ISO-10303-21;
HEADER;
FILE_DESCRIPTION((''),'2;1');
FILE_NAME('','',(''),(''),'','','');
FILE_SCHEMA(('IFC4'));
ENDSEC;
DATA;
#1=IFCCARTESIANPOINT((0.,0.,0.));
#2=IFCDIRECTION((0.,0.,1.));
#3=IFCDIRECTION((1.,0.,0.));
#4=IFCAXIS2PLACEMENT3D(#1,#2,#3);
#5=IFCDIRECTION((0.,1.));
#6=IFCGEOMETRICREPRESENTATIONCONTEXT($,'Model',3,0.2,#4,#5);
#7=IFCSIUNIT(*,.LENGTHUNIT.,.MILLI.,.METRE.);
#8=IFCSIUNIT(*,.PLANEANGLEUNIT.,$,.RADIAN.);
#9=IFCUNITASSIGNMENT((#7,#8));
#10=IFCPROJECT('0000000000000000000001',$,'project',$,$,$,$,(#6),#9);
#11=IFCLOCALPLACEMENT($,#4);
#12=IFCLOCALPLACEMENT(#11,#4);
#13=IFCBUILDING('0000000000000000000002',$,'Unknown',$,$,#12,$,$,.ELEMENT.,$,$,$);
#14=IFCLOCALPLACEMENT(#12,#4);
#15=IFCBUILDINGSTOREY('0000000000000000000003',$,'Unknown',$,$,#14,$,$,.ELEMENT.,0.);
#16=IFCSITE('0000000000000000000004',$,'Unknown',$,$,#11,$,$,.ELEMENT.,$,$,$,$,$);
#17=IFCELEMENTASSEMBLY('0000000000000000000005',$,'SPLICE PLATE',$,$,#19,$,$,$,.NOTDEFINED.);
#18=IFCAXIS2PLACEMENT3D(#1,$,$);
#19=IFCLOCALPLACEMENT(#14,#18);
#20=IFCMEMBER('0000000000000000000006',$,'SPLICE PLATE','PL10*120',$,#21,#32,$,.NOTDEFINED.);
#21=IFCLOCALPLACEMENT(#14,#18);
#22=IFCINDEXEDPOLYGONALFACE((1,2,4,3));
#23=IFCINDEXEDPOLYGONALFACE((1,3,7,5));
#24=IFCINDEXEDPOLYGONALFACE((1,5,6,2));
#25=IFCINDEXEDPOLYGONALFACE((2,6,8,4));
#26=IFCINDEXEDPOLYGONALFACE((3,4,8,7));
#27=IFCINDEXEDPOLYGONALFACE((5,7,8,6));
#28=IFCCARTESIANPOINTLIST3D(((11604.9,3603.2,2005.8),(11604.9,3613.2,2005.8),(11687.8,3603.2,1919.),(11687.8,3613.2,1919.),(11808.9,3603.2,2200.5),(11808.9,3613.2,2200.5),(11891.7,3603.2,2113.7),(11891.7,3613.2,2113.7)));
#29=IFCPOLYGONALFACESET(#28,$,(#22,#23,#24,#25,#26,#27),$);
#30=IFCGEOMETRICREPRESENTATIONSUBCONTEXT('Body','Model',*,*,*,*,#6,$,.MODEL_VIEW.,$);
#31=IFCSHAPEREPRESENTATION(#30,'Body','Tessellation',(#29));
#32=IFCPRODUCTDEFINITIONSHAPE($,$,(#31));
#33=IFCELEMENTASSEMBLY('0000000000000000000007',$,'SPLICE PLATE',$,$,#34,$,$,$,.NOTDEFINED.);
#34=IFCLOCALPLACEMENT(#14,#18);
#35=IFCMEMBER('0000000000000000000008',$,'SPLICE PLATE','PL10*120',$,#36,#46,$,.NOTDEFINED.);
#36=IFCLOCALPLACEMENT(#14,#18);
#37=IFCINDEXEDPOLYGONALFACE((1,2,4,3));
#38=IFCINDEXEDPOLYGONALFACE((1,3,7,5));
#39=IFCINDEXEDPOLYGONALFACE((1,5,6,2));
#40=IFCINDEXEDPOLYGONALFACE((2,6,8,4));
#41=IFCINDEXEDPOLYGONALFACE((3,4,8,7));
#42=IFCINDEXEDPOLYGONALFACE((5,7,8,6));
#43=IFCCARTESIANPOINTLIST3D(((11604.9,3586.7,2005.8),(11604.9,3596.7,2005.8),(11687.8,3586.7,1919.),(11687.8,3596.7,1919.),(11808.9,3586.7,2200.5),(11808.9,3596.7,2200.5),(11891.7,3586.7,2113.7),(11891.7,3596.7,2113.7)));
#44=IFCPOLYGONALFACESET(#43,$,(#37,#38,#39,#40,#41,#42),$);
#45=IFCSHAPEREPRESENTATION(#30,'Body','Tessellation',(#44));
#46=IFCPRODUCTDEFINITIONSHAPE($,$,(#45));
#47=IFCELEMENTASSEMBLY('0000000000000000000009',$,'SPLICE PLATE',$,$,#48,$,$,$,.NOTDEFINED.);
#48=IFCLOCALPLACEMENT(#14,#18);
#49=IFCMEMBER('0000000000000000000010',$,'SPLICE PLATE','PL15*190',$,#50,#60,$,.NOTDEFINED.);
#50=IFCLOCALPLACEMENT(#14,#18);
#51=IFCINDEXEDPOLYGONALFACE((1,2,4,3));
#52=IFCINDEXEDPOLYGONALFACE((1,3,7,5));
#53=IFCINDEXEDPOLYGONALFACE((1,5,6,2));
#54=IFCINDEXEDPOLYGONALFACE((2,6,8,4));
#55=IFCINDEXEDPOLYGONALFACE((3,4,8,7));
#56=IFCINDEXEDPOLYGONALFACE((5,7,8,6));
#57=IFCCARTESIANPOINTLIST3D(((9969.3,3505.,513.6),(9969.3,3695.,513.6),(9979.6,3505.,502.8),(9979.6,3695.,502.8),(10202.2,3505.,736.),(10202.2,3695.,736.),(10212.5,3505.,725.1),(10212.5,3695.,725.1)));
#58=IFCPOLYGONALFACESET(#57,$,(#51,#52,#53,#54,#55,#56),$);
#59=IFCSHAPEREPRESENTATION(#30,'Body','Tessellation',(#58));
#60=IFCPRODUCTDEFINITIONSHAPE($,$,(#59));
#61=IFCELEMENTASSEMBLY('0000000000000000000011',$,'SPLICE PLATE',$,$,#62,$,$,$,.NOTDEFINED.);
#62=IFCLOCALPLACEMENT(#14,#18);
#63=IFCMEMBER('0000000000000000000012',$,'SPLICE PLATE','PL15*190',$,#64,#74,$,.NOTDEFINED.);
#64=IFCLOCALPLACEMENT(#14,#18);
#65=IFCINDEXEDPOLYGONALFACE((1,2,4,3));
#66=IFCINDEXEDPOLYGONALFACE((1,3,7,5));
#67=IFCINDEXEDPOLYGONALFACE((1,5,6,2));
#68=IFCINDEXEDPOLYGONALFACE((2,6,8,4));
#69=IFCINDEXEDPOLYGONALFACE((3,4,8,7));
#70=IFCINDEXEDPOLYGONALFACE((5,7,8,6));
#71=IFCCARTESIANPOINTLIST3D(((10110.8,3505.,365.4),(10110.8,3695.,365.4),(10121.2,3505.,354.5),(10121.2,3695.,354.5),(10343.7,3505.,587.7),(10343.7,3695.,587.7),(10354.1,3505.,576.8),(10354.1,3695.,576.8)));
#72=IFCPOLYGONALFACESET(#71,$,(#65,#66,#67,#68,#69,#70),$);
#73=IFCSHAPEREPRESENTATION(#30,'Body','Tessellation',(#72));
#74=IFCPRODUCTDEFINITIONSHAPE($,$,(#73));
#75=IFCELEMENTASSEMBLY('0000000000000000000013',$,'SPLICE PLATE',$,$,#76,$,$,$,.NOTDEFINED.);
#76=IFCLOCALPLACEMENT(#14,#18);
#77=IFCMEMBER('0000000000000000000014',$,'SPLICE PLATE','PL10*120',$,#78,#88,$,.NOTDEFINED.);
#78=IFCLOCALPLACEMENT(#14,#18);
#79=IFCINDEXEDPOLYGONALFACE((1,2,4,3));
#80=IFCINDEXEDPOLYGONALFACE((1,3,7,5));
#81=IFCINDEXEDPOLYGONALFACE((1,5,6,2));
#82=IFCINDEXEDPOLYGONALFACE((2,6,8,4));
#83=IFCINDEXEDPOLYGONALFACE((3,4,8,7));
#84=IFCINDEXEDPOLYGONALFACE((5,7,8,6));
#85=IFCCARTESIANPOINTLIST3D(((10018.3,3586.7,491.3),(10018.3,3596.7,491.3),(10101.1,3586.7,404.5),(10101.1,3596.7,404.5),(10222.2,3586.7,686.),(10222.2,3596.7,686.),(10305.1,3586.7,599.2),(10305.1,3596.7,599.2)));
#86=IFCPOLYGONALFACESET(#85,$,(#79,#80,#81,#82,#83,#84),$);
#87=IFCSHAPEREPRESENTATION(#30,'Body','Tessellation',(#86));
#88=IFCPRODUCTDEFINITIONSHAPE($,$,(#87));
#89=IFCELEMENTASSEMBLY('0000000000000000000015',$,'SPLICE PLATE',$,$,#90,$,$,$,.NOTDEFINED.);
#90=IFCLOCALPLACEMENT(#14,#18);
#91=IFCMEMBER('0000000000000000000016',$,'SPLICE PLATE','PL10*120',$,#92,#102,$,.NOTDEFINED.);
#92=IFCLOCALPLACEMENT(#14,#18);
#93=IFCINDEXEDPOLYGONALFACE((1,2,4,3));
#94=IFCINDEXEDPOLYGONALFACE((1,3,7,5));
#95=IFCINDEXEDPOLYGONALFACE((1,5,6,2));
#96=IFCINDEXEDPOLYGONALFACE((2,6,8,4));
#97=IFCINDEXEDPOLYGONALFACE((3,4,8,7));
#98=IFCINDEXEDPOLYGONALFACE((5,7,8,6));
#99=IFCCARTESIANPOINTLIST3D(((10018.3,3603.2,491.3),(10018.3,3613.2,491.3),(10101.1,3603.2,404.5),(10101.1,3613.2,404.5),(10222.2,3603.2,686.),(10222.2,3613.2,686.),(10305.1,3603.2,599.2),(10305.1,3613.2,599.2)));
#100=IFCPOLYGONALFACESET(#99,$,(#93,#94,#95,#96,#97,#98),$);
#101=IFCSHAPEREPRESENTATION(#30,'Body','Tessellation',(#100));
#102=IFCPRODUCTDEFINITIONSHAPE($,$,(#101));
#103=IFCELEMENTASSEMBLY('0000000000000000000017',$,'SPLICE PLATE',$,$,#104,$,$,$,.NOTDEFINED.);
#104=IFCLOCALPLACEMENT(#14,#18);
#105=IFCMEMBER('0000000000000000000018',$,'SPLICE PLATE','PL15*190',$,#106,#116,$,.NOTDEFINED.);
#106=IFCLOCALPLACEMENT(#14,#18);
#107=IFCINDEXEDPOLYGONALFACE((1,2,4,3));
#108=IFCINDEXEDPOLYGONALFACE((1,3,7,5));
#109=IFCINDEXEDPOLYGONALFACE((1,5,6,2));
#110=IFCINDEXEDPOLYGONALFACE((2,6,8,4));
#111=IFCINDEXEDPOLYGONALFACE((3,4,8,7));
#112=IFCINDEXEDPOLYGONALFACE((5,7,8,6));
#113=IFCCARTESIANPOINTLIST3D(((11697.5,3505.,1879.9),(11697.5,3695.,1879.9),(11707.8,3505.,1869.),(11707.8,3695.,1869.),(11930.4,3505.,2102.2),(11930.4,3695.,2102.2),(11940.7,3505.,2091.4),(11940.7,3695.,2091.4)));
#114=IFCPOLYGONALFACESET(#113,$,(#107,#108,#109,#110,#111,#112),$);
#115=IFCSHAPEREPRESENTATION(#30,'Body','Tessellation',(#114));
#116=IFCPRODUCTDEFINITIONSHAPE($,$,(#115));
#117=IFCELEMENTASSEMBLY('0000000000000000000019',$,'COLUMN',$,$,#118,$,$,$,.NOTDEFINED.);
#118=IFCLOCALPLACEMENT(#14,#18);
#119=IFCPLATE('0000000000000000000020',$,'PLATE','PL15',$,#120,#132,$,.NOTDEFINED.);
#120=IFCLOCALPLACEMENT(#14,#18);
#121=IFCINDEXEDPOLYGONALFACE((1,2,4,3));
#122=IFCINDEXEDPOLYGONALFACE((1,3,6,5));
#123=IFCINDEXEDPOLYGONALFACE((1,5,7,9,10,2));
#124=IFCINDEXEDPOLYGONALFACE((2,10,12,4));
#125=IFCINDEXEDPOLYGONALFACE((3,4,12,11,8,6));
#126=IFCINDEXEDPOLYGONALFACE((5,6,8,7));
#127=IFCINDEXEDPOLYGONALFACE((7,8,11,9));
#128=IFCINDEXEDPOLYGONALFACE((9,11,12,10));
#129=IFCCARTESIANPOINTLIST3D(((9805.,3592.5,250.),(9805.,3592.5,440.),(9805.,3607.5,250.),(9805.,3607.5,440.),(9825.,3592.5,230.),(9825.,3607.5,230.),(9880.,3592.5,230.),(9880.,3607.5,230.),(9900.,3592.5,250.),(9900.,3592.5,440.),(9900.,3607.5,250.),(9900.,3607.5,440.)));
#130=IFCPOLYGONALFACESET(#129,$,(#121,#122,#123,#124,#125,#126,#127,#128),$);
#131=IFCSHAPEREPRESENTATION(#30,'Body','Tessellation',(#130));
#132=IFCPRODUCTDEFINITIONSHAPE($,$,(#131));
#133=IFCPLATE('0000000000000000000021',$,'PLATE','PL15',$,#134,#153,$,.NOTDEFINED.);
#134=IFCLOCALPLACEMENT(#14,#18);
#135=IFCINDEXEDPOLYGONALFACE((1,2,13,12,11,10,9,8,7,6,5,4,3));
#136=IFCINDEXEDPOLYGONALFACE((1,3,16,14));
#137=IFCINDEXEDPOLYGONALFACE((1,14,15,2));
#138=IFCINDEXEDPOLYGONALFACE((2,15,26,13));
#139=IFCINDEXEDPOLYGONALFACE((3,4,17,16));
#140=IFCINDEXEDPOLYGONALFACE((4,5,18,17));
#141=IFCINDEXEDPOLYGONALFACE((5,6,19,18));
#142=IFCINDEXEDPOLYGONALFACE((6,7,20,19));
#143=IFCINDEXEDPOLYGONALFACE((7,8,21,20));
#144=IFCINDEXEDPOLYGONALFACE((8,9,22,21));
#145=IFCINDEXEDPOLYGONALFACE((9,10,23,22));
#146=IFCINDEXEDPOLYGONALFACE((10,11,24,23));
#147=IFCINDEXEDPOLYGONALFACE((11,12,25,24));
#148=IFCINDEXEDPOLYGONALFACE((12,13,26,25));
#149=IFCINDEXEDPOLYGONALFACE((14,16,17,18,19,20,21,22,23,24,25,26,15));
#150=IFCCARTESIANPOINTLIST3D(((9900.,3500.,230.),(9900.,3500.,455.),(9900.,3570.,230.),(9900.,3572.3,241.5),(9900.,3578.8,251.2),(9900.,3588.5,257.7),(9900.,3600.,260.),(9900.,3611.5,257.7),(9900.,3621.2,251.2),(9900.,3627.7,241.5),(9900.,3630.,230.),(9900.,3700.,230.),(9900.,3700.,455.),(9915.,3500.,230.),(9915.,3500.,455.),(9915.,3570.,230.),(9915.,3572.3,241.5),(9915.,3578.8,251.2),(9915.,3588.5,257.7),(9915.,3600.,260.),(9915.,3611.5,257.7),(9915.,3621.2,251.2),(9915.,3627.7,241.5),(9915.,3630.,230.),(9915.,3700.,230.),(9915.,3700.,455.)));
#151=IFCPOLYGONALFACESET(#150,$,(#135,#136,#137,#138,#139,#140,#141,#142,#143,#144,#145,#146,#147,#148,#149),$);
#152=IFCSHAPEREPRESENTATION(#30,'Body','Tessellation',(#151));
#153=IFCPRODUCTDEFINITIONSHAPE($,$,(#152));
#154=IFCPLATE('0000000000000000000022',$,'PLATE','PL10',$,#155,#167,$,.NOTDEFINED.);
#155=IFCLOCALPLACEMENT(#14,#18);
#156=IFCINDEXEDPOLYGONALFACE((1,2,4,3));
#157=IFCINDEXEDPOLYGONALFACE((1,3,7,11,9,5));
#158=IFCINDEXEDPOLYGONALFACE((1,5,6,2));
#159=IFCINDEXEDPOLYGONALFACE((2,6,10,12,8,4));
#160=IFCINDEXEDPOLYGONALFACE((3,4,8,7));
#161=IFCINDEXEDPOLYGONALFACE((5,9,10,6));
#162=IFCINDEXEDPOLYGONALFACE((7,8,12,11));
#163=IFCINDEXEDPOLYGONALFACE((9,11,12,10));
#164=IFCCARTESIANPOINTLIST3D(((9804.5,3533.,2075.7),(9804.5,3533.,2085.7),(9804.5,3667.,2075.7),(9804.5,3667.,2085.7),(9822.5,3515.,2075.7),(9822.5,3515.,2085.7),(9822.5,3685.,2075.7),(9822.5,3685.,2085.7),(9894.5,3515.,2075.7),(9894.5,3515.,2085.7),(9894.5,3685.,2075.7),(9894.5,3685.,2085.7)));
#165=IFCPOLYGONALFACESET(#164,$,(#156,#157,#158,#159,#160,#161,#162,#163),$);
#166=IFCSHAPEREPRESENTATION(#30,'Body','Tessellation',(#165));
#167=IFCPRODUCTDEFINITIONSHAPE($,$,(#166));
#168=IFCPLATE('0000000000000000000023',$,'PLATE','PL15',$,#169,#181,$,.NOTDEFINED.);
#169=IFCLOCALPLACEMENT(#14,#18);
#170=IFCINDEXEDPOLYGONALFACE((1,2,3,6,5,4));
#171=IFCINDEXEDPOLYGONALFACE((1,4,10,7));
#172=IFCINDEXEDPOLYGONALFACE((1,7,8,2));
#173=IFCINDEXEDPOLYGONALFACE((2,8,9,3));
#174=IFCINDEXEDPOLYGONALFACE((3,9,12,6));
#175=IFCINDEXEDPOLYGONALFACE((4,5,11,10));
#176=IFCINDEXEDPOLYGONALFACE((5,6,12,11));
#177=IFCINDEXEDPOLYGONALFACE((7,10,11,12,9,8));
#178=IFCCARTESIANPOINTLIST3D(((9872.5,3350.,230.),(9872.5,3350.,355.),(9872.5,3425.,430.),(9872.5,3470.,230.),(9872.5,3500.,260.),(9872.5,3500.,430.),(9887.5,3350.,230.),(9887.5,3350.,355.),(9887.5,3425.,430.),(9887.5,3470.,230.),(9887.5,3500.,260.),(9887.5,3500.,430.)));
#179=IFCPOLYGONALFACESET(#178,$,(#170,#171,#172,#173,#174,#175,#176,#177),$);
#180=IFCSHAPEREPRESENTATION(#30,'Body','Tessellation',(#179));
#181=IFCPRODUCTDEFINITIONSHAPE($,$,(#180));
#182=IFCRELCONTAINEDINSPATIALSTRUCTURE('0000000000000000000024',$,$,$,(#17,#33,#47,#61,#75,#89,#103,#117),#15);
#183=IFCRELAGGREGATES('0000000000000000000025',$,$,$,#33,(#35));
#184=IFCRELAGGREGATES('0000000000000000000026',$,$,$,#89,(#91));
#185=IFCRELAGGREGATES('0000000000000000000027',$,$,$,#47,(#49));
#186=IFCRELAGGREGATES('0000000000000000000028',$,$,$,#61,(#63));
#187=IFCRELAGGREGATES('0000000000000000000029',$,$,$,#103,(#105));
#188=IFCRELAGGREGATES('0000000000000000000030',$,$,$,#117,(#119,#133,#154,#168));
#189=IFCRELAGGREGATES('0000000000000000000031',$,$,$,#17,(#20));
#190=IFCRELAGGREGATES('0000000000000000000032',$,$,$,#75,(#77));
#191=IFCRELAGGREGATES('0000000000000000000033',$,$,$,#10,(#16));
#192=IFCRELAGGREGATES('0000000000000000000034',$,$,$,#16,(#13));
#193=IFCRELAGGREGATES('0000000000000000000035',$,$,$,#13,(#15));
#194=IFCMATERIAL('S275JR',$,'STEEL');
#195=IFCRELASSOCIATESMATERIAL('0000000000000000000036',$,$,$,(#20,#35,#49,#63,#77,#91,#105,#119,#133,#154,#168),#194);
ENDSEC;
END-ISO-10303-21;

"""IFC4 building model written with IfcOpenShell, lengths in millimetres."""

from ifc_helpers import new_model, si_unit, direction, frame, origin_with_axes, place, context, subcontext, project, spatial, line, indexed_curve, outline, extrude, material, element, aggregate, save


model = new_model("IFC4")

# Units and contexts
model_context = context("Model", 3, precision=0.2, world=origin_with_axes(), true_north=direction((0.0, 1.0)))
body_context = subcontext(model_context, "Body", "Model", "MODEL_VIEW")
ifc_project = project(units=[si_unit("LENGTHUNIT", "METRE", prefix="MILLI"), si_unit("PLANEANGLEUNIT", "RADIAN")], contexts=[model_context])

# Site, building, storey
site_placement = place(None, origin_with_axes())
site = spatial("IfcSite", under=ifc_project, at=site_placement, Name="Unknown", CompositionType="ELEMENT")
building_placement = place(site_placement, origin_with_axes())
building = spatial("IfcBuilding", under=site, at=building_placement, Name="Unknown", CompositionType="ELEMENT")
storey_placement = place(building_placement, origin_with_axes())
storey = spatial("IfcBuildingStorey", under=building, at=storey_placement, Name="Unknown", CompositionType="ELEMENT", Elevation=0.0)

# Element assemblies, members
assembly_1_placement = place(storey_placement, frame((11850.3, 3608.2, 2157.1), z_axis=(0.0, 1.0, 0.0), x_axis=(-0.723355, 0.0, -0.690476)))
assembly_1 = element("IfcElementAssembly", 1, at=assembly_1_placement, inside=storey, Name="SPLICE PLATE", PredefinedType="NOTDEFINED")
ifc_material_1 = material(Name="S275JR", Category="STEEL")
member_1_placement = place(assembly_1_placement, origin_with_axes())
member_1 = element("IfcMember", 2, at=member_1_placement, material=ifc_material_1, Name="SPLICE PLATE", Description="PL10*120", PredefinedType="NOTDEFINED", context=body_context, shape_type="SolidModel", body=[
    extrude(outline(indexed_curve([(-5.0, -60.0), (5.0, -60.0), (5.0, 60.0), (-5.0, 60.0)], segments=[line(1, 2, 3, 4, 1)])), frame((0.0, 0.0, 0.0), z_axis=(-1.0, 0.0, 0.0), x_axis=(0.0, 0.0, 1.0)), (0.0, -0.000002, -1.0), 282.0),
])
assembly_2_placement = place(storey_placement, frame((11850.3, 3591.7, 2157.1), z_axis=(0.0, 1.0, 0.0), x_axis=(-0.723355, 0.0, -0.690476)))
assembly_2 = element("IfcElementAssembly", 3, at=assembly_2_placement, inside=storey, Name="SPLICE PLATE", PredefinedType="NOTDEFINED")
member_2_placement = place(assembly_2_placement, origin_with_axes())
member_2 = element("IfcMember", 4, at=member_2_placement, material=ifc_material_1, Name="SPLICE PLATE", Description="PL10*120", PredefinedType="NOTDEFINED", context=body_context, shape_type="SolidModel", body=[
    extrude(outline(indexed_curve([(-5.0, -60.0), (5.0, -60.0), (5.0, 60.0), (-5.0, 60.0)], segments=[line(1, 2, 3, 4, 1)])), frame((0.0, 0.0, 0.0), z_axis=(-1.0, 0.0, 0.0), x_axis=(0.0, 0.0, 1.0)), (0.0, -0.000002, -1.0), 282.0),
])
aggregate(assembly_2, [member_2])
assembly_3_placement = place(storey_placement, frame((9974.4, 3600.0, 508.2), z_axis=(0.690476, 0.0, -0.723355), x_axis=(0.723355, 0.0, 0.690476)))
assembly_3 = element("IfcElementAssembly", 5, at=assembly_3_placement, inside=storey, Name="SPLICE PLATE", PredefinedType="NOTDEFINED")
member_3_placement = place(assembly_3_placement, origin_with_axes())
member_3 = element("IfcMember", 6, at=member_3_placement, material=ifc_material_1, Name="SPLICE PLATE", Description="PL15*190", PredefinedType="NOTDEFINED", context=body_context, shape_type="SolidModel", body=[
    extrude(outline(indexed_curve([(-7.5, -95.0), (7.5, -95.0), (7.5, 95.0), (-7.5, 95.0)], segments=[line(1, 2, 3, 4, 1)])), frame((0.0, 0.0, 0.0), z_axis=(-1.0, 0.0, 0.0), x_axis=(0.0, 0.0, 1.0)), (0.0, -0.000002, -1.0), 322.0),
])
assembly_4_placement = place(storey_placement, frame((10116.0, 3600.0, 359.9), z_axis=(0.690476, 0.0, -0.723355), x_axis=(0.723355, 0.0, 0.690476)))
assembly_4 = element("IfcElementAssembly", 7, at=assembly_4_placement, inside=storey, Name="SPLICE PLATE", PredefinedType="NOTDEFINED")
member_4_placement = place(assembly_4_placement, origin_with_axes())
member_4 = element("IfcMember", 8, at=member_4_placement, material=ifc_material_1, Name="SPLICE PLATE", Description="PL15*190", PredefinedType="NOTDEFINED", context=body_context, shape_type="SolidModel", body=[
    extrude(outline(indexed_curve([(-7.5, -95.0), (7.5, -95.0), (7.5, 95.0), (-7.5, 95.0)], segments=[line(1, 2, 3, 4, 1)])), frame((0.0, 0.0, 0.0), z_axis=(-1.0, 0.0, 0.0), x_axis=(0.0, 0.0, 1.0)), (0.0, -0.000002, -1.0), 322.0),
])
assembly_5_placement = place(storey_placement, frame((10059.7, 3591.7, 447.9), z_axis=(-0.000002, -1.0, 0.0), x_axis=(0.723355, 0.0, 0.690476)))
assembly_5 = element("IfcElementAssembly", 9, at=assembly_5_placement, inside=storey, Name="SPLICE PLATE", PredefinedType="NOTDEFINED")
member_5_placement = place(assembly_5_placement, origin_with_axes())
member_5 = element("IfcMember", 10, at=member_5_placement, material=ifc_material_1, Name="SPLICE PLATE", Description="PL10*120", PredefinedType="NOTDEFINED", context=body_context, shape_type="SolidModel", body=[
    extrude(outline(indexed_curve([(-5.0, -60.0), (5.0, -60.0), (5.0, 60.0), (-5.0, 60.0)], segments=[line(1, 2, 3, 4, 1)])), frame((0.0, 0.0, 0.0), z_axis=(-1.0, 0.0, 0.0), x_axis=(0.0, 0.0, 1.0)), (0.0, -0.000002, -1.0), 282.0),
])
assembly_6_placement = place(storey_placement, frame((10059.7, 3608.2, 447.9), z_axis=(-0.000002, -1.0, 0.0), x_axis=(0.723355, 0.0, 0.690476)))
assembly_6 = element("IfcElementAssembly", 11, at=assembly_6_placement, inside=storey, Name="SPLICE PLATE", PredefinedType="NOTDEFINED")
member_6_placement = place(assembly_6_placement, origin_with_axes())
member_6 = element("IfcMember", 12, at=member_6_placement, material=ifc_material_1, Name="SPLICE PLATE", Description="PL10*120", PredefinedType="NOTDEFINED", context=body_context, shape_type="SolidModel", body=[
    extrude(outline(indexed_curve([(-5.0, -60.0), (5.0, -60.0), (5.0, 60.0), (-5.0, 60.0)], segments=[line(1, 2, 3, 4, 1)])), frame((0.0, 0.0, 0.0), z_axis=(-1.0, 0.0, 0.0), x_axis=(0.0, 0.0, 1.0)), (0.0, -0.000002, -1.0), 282.0),
])
aggregate(assembly_6, [member_6])
assembly_7_placement = place(storey_placement, frame((11935.6, 3600.0, 2096.8), z_axis=(0.690476, 0.0, -0.723355), x_axis=(-0.723355, 0.0, -0.690476)))
assembly_7 = element("IfcElementAssembly", 13, at=assembly_7_placement, inside=storey, Name="SPLICE PLATE", PredefinedType="NOTDEFINED")
member_7_placement = place(assembly_7_placement, origin_with_axes())
member_7 = element("IfcMember", 14, at=member_7_placement, material=ifc_material_1, Name="SPLICE PLATE", Description="PL15*190", PredefinedType="NOTDEFINED", context=body_context, shape_type="SolidModel", body=[
    extrude(outline(indexed_curve([(-7.5, -95.0), (7.5, -95.0), (7.5, 95.0), (-7.5, 95.0)], segments=[line(1, 2, 3, 4, 1)])), frame((0.0, 0.0, 0.0), z_axis=(-1.0, 0.0, 0.0), x_axis=(0.0, 0.0, 1.0)), (0.0, -0.000002, -1.0), 322.0),
])

# Element assembly, plates, voiding feature
assembly_8_placement = place(storey_placement, frame((9800.0, 3600.0, 200.0), z_axis=(-1.0, 0.0, 0.0), x_axis=(0.0, 0.0, 1.0)))
assembly_8 = element("IfcElementAssembly", 15, at=assembly_8_placement, inside=storey, Name="COLUMN", PredefinedType="NOTDEFINED")
plate_1_placement = place(assembly_8_placement, frame((240.0, 0.0, -100.0), z_axis=(-0.000002, -1.0, 0.0), x_axis=(0.0, 0.0, 1.0)))
plate_1 = element("IfcPlate", 16, at=plate_1_placement, material=ifc_material_1, Name="PLATE", Description="PL15", PredefinedType="NOTDEFINED", context=body_context, shape_type="SolidModel", body=[
    extrude(outline(indexed_curve([(0.0, 0.0), (95.0, 0.0), (95.0, 190.0), (75.0, 210.0), (20.0, 210.0), (0.0, 190.0)], segments=[line(1, 2, 3, 4, 5, 6, 1)])), frame((0.0, 0.0, 7.5), z_axis=(0.0, 0.0, 1.0), x_axis=(1.0, 0.0, 0.0)), (0.0, -0.000002, -1.0), 15.0),
])
plate_2_placement = place(assembly_8_placement, frame((30.0, 100.0, -107.5), z_axis=(0.0, -0.000002, -1.0), x_axis=(1.0, 0.0, 0.0)))
plate_2 = element("IfcPlate", 17, at=plate_2_placement, material=ifc_material_1, Name="PLATE", Description="PL15", PredefinedType="NOTDEFINED", context=body_context, shape_type="SolidModel", body=[
    extrude(outline(indexed_curve([(0.0, 0.0), (225.0, 0.0), (225.0, 200.0), (0.0, 200.0)], segments=[line(1, 2, 3, 4, 1)])), frame((0.0, 0.0, 7.5), z_axis=(0.0, 0.0, 1.0), x_axis=(1.0, 0.0, 0.0)), (0.0, -0.000002, -1.0), 15.0),
])
voiding_feature_placement = place(plate_2_placement, frame((0.0, 100.0, -27.5), z_axis=(0.0, 1.0, 0.0), x_axis=(0.0, 0.0, 1.0)))
element("IfcVoidingFeature", 18, at=voiding_feature_placement, cuts=plate_2, Name="BEAM", PredefinedType="HOLE", context=body_context, shape_type="SolidModel", body=[
    extrude(outline(indexed_curve([(30.0, 0.0), (27.7, 11.5), (21.2, 21.2), (11.5, 27.7), (0.0, 30.0), (-11.5, 27.7), (-21.2, 21.2), (-27.7, 11.5), (-30.0, 0.0), (-27.7, -11.5), (-21.2, -21.2), (-11.5, -27.7), (0.0, -30.0), (11.5, -27.7), (21.2, -21.2), (27.7, -11.5)], segments=[line(1, 2, 3, 4, 5, 6, 7, 8, 9, 10, 11, 12, 13, 14, 15, 16, 1)])), frame((0.0, 0.0, 0.0), z_axis=(-1.0, 0.0, 0.0), x_axis=(0.0, 0.0, 1.0)), (0.0, -0.000002, -1.0), 120.0),
])
plate_3_placement = place(assembly_8_placement, frame((1880.7, -85.0, -94.5), z_axis=(-1.0, 0.0, 0.0), x_axis=(0.0, 0.0, 1.0)))
plate_3 = element("IfcPlate", 19, at=plate_3_placement, material=ifc_material_1, Name="PLATE", Description="PL10", PredefinedType="NOTDEFINED", context=body_context, shape_type="SolidModel", body=[
    extrude(outline(indexed_curve([(0.0, 0.0), (72.0, 0.0), (90.0, 18.0), (90.0, 152.0), (72.0, 170.0), (0.0, 170.0)], segments=[line(1, 2, 3, 4, 5, 6, 1)])), frame((0.0, 0.0, 5.0), z_axis=(0.0, 0.0, 1.0), x_axis=(1.0, 0.0, 0.0)), (0.0, -0.000002, -1.0), 10.0),
])
plate_4_placement = place(assembly_8_placement, frame((60.0, -100.0, -80.0), z_axis=(0.0, 0.0, 1.0), x_axis=(-0.707116, -0.707097, 0.0)))
plate_4 = element("IfcPlate", 20, at=plate_4_placement, material=ifc_material_1, Name="PLATE", Description="PL15", PredefinedType="NOTDEFINED", context=body_context, shape_type="SolidModel", body=[
    extrude(outline(indexed_curve([(0.0, 0.0), (42.4, 0.0), (127.3, 84.9), (38.9, 173.2), (-67.2, 173.2), (-120.2, 120.2)], segments=[line(1, 2, 3, 4, 5, 6, 1)])), frame((0.0, 0.0, 7.5), z_axis=(0.0, 0.0, 1.0), x_axis=(1.0, 0.0, 0.0)), (0.0, -0.000002, -1.0), 15.0),
])

aggregate(assembly_3, [member_3])
aggregate(assembly_4, [member_4])

aggregate(assembly_7, [member_7])
aggregate(assembly_8, [plate_1, plate_2, plate_3, plate_4])
aggregate(assembly_1, [member_1])
aggregate(assembly_5, [member_5])

save(model, "model.ifc")
